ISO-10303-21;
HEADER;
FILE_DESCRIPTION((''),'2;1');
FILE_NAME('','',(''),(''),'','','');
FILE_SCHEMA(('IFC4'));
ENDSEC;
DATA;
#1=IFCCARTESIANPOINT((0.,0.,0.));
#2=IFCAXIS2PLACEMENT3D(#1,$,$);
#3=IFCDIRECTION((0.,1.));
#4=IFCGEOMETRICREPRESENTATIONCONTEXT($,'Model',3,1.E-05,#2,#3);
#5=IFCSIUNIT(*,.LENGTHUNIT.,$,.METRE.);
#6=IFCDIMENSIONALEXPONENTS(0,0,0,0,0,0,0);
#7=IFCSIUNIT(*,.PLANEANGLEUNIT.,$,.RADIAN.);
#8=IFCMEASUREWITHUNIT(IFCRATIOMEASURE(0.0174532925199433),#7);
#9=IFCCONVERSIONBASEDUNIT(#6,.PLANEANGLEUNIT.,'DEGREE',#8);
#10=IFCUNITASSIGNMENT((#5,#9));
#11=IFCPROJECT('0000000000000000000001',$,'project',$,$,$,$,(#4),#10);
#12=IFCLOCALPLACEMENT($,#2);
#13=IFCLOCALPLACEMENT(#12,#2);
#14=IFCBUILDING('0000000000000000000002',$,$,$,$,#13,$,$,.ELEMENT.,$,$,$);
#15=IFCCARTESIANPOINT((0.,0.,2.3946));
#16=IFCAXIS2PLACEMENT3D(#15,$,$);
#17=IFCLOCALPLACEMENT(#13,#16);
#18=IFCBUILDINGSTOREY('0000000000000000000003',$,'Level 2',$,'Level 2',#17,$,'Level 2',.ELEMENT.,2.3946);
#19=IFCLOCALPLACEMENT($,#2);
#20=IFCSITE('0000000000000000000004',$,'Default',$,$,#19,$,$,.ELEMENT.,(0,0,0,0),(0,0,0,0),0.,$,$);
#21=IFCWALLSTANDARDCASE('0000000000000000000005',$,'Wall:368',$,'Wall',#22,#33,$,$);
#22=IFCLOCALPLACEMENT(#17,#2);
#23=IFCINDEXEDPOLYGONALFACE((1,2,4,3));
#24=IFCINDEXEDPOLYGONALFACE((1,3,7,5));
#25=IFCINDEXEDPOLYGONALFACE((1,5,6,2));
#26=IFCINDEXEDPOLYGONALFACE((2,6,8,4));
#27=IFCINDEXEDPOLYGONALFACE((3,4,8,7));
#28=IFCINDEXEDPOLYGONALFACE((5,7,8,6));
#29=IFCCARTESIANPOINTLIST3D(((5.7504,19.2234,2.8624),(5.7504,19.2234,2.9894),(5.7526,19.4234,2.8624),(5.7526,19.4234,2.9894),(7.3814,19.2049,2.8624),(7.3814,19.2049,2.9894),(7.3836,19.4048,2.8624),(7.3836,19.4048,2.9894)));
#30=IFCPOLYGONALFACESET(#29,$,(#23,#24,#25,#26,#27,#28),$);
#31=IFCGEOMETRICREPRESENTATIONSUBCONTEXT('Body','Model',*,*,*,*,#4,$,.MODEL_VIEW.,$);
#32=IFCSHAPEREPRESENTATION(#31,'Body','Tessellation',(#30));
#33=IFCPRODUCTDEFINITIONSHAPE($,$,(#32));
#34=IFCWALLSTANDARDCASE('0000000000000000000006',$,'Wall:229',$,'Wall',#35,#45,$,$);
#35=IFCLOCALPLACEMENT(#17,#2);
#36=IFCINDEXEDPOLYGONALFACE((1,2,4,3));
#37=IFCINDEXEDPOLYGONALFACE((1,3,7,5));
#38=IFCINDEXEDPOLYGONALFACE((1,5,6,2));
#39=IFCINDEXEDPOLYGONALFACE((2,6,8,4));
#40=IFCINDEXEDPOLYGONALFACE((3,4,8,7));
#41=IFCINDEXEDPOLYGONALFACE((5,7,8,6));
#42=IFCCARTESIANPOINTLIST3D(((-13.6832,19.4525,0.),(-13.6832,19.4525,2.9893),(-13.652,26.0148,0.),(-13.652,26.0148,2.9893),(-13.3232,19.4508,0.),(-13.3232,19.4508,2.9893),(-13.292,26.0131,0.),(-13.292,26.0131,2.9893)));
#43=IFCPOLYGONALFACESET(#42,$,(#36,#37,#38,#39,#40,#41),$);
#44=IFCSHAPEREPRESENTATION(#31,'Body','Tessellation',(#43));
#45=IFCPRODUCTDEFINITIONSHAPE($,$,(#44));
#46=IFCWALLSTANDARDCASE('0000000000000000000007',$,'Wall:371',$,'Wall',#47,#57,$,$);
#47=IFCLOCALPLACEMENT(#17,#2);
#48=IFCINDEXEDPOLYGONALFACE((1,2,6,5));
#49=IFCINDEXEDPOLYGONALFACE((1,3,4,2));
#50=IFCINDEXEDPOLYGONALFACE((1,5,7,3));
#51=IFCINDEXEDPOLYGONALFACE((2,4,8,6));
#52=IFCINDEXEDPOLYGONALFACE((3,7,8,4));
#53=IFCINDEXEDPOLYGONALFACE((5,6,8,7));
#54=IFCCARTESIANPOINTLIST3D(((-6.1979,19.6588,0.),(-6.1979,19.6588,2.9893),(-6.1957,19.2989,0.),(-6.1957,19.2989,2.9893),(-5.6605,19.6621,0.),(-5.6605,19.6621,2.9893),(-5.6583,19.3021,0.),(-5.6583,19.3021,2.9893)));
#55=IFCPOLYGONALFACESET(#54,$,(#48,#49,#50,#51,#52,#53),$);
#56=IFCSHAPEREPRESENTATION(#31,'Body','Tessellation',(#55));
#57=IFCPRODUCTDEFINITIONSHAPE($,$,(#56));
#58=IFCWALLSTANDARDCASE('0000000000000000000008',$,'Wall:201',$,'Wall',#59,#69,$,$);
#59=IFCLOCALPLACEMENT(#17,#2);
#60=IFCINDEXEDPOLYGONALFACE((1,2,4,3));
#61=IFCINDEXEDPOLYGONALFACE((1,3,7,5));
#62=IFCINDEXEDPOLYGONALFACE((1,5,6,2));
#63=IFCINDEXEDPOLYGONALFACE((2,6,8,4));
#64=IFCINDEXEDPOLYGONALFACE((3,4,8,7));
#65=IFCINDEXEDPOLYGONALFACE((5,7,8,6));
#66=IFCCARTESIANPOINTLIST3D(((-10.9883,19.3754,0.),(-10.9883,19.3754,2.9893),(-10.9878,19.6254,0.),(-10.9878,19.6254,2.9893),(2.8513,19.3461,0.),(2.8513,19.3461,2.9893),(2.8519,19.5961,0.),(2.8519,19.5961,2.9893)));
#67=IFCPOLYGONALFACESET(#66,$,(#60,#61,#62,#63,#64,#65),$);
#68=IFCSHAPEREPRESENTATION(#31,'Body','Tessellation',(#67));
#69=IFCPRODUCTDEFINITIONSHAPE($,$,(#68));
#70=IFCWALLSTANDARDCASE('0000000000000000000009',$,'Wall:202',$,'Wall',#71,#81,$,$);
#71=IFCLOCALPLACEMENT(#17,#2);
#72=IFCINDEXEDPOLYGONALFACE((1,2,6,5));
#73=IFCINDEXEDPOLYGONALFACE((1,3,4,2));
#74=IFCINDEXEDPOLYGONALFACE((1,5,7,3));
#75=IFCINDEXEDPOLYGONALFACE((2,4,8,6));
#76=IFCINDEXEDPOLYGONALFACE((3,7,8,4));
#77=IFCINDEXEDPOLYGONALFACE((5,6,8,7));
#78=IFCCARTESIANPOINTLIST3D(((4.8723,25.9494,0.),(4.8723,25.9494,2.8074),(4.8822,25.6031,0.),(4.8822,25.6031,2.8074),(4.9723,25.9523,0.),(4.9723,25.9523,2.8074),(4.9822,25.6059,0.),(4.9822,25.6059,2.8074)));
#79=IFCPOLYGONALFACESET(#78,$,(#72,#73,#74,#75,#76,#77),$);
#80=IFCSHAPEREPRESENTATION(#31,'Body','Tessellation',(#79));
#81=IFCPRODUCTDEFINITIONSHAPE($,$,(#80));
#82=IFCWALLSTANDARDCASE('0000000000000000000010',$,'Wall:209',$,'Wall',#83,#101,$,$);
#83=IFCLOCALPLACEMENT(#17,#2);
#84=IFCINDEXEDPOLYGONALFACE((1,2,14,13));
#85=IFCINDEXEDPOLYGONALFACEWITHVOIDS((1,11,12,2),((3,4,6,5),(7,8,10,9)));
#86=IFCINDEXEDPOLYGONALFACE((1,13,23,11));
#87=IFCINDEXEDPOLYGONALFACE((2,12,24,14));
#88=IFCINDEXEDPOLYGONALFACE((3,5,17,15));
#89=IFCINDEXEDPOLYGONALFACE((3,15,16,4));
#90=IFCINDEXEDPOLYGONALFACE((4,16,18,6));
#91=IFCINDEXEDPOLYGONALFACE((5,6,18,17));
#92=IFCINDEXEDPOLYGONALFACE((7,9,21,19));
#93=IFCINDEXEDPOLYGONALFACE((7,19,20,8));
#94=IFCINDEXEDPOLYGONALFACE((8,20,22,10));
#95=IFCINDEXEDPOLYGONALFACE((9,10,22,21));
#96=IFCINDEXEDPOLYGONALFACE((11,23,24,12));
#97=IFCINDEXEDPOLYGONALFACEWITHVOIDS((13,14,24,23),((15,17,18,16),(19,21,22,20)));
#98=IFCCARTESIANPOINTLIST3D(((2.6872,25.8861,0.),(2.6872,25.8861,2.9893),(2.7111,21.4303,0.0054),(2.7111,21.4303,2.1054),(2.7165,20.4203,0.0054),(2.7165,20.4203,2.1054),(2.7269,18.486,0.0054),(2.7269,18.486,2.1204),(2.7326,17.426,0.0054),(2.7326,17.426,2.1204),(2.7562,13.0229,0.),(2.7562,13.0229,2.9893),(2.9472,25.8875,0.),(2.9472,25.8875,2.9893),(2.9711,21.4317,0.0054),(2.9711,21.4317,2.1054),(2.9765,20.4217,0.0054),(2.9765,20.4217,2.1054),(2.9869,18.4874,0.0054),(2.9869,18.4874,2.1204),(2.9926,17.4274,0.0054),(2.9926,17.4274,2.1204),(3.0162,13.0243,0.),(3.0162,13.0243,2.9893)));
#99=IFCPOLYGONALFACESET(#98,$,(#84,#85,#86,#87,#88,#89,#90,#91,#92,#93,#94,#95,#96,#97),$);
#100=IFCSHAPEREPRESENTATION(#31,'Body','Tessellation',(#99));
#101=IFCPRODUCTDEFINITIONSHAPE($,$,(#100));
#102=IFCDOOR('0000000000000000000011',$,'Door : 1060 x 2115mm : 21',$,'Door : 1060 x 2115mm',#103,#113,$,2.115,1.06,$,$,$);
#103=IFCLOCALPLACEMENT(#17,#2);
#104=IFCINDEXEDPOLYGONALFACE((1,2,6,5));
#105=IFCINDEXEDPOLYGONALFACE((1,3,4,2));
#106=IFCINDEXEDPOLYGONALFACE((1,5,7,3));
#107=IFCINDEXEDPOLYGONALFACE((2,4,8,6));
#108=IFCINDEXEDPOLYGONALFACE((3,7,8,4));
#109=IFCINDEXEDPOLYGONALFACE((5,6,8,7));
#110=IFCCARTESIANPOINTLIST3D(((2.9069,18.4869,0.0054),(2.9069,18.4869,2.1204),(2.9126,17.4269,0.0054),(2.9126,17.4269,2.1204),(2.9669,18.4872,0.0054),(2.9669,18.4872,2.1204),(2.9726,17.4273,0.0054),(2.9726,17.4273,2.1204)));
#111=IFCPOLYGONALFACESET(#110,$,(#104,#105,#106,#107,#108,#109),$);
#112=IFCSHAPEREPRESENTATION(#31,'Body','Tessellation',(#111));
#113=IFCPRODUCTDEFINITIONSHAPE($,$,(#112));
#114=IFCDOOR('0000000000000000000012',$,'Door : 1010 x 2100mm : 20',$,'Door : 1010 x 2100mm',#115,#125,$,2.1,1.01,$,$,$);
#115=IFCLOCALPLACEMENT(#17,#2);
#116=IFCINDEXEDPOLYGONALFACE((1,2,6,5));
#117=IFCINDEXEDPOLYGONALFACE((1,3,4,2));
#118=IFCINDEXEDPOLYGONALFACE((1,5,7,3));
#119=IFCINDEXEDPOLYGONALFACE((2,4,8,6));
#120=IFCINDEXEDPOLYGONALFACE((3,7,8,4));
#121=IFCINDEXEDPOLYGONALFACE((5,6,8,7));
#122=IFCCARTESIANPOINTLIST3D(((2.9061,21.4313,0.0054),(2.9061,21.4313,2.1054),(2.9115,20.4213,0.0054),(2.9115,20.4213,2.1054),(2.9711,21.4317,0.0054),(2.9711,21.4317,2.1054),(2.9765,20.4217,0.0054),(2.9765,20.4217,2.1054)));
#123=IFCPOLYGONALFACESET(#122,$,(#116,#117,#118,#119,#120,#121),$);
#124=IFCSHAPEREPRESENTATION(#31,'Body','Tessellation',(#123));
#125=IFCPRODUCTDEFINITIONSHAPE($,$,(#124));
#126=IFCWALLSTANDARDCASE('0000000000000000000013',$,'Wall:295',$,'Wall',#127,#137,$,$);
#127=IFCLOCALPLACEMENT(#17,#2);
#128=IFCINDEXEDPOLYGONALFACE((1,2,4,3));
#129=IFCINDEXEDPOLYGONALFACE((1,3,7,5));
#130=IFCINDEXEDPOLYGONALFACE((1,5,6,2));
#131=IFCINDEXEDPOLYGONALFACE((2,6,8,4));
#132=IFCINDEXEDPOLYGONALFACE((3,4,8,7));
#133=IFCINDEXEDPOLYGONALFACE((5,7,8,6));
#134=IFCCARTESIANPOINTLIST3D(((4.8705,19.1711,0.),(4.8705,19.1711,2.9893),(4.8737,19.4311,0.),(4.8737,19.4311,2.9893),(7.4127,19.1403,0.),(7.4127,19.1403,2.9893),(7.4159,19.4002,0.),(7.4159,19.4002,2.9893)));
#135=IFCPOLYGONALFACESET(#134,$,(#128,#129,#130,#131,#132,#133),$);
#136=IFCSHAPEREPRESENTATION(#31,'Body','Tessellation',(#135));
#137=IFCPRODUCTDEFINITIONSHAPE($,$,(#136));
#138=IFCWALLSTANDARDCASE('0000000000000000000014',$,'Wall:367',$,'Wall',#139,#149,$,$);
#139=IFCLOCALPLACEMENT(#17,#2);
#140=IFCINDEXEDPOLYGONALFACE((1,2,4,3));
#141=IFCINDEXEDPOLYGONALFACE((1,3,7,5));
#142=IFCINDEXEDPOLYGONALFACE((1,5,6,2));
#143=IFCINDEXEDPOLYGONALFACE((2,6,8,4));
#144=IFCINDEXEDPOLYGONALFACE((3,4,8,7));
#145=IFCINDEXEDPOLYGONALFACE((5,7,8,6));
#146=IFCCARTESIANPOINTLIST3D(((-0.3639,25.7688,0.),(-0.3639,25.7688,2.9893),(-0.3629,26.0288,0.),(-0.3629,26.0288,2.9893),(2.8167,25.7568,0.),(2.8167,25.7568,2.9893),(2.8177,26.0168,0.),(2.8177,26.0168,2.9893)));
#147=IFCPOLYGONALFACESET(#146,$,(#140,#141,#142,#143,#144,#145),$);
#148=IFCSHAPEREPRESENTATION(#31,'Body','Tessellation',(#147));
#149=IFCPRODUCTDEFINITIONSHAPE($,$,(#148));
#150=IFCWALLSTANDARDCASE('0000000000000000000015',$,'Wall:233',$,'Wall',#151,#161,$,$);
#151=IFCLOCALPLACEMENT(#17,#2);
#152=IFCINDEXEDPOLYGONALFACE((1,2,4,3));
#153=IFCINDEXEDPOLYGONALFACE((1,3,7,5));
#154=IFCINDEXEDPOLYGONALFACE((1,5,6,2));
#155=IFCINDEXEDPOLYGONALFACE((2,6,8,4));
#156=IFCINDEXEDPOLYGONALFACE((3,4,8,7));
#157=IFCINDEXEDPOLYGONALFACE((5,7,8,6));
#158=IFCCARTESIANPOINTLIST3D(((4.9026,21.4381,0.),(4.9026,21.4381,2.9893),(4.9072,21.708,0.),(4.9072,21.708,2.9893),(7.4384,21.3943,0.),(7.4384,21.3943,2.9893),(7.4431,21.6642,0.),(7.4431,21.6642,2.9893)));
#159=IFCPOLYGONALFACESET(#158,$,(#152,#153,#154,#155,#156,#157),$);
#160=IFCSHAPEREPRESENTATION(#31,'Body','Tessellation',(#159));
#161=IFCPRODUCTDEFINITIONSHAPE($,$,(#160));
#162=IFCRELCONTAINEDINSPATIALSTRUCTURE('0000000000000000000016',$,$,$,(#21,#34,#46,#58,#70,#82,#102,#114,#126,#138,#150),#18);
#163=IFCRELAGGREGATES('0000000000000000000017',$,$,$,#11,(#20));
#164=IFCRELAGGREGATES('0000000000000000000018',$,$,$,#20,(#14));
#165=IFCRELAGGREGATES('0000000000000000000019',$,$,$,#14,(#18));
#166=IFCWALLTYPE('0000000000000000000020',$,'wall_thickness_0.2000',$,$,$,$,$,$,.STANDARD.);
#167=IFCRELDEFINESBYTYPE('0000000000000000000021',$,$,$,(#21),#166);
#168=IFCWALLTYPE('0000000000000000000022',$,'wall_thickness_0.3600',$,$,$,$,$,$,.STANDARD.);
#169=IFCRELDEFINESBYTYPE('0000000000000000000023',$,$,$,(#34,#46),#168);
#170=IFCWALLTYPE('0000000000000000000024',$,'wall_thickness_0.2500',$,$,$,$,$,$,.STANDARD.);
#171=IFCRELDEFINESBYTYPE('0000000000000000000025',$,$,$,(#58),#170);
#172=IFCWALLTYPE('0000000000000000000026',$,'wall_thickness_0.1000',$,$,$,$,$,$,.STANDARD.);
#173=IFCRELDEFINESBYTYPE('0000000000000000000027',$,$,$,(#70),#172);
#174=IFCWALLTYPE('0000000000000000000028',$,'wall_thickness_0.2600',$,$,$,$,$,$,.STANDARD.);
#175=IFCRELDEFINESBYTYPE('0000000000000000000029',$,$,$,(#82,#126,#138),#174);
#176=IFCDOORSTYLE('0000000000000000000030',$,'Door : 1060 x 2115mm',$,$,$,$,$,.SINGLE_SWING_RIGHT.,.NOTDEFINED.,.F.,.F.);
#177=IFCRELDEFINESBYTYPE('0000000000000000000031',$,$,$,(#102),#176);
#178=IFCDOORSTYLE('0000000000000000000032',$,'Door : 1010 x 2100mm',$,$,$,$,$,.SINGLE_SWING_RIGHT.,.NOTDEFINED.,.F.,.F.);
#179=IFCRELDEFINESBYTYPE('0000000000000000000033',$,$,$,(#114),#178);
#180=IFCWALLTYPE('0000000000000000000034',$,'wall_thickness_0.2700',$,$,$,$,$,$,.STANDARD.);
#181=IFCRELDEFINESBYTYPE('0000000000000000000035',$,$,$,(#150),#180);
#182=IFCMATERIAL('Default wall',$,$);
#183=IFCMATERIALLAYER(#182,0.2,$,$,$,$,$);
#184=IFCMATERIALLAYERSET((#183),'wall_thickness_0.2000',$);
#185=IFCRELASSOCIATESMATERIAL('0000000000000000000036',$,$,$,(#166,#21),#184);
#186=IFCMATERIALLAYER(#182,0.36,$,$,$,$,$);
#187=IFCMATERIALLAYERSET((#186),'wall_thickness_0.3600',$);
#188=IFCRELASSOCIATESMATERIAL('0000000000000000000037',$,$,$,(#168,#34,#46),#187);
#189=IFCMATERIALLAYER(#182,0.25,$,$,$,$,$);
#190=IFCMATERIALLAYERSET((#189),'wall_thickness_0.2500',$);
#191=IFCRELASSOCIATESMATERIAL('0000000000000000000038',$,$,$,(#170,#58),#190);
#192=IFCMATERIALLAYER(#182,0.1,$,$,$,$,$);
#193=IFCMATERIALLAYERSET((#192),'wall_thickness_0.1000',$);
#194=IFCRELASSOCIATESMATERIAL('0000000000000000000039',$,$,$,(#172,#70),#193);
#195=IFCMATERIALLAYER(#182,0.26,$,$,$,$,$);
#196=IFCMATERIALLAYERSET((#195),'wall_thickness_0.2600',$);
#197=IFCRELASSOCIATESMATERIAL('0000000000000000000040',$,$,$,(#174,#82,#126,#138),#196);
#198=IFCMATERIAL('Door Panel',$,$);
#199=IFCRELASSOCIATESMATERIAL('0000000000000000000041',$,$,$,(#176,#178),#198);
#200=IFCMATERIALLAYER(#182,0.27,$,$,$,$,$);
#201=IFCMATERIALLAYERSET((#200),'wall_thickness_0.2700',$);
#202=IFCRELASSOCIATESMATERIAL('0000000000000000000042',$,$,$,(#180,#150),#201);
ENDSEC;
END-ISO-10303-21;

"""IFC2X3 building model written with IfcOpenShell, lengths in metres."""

from ifc_helpers import new_model, entity, si_unit, converted_unit, direction, frame, frame_2d, origin, origin_2d_with_axis, place, context, subcontext, project, spatial, polyline, rectangle, outline, extrude, source, transform, mapped, material, layer, layer_set, layer_usage, type_object, type_shapes, element, fill, save


model = new_model("IFC2X3")

# Units and contexts
model_context = context("Model", 3, precision=1e-05, world=origin(), true_north=direction((0.0, 1.0)))
body_context = subcontext(model_context, "Body", "Model", "MODEL_VIEW")
ifc_project = project(units=[si_unit("LENGTHUNIT", "METRE"), converted_unit("PLANEANGLEUNIT", "DEGREE", entity("IfcRatioMeasure", 0.0174532925199433), si_unit("PLANEANGLEUNIT", "RADIAN"), dimensions=[0, 0, 0, 0, 0, 0, 0])], contexts=[model_context])

# Site, building, storey
site_placement = place(None, origin())
site = spatial("IfcSite", under=ifc_project, at=site_placement, Name="Default", CompositionType="ELEMENT", RefLatitude=(0, 0, 0, 0), RefLongitude=(0, 0, 0, 0), RefElevation=0.0)
placement_1 = place(None, origin())
building_placement = place(placement_1, origin())
building = spatial("IfcBuilding", under=site, at=building_placement, CompositionType="ELEMENT")
storey_placement = place(building_placement, frame((0.0, 0.0, 2.3946)))
storey = spatial("IfcBuildingStorey", under=building, at=storey_placement, Name="Level 2", ObjectType="Level 2", LongName="Level 2", CompositionType="ELEMENT", Elevation=2.3946)

# Shared definitions
ifc_material_1 = material(Name="Default wall")

# Walls
ifc_layer_1 = layer(ifc_material_1, 0.2)
ifc_layer_set_1 = layer_set([ifc_layer_1], Name="wall_thickness_0.2000")
ifc_layer_usage_1 = layer_usage(ifc_layer_set_1, "AXIS2", "POSITIVE", -0.1)
wall_type_1 = type_object("IfcWallType", Name="wall_thickness_0.2000", PredefinedType="STANDARD", material=ifc_layer_set_1)
placement_2 = place(building_placement, frame((0.0, 0.0, 5.257)))
wall_1_placement = place(placement_2, frame((5.7515, 19.3234, 0.0), z_axis=(0.0, 0.0, 1.0), x_axis=(0.999935, -0.011381, 0.0)))
element("IfcWallStandardCase", 1, at=wall_1_placement, inside=storey, type_object=wall_type_1, material=ifc_layer_usage_1, Name="Wall:368", ObjectType="Wall", context=body_context, shape_type="SweptSolid", body=[
    extrude(outline(polyline([(1.6311, -0.1), (1.6311, 0.1), (0.0, 0.1), (0.0, -0.1), (1.6311, -0.1)])), origin(), (0.0, 0.0, 1.0), 0.127),
])
ifc_layer_2 = layer(ifc_material_1, 0.36)
ifc_layer_set_2 = layer_set([ifc_layer_2], Name="wall_thickness_0.3600")
ifc_layer_usage_2 = layer_usage(ifc_layer_set_2, "AXIS2", "POSITIVE", -0.18)
wall_type_2 = type_object("IfcWallType", Name="wall_thickness_0.3600", PredefinedType="STANDARD", material=ifc_layer_set_2)
wall_2_placement = place(storey_placement, frame((-13.472, 26.014, 0.0), z_axis=(0.0, 0.0, 1.0), x_axis=(-0.004758, -0.999989, 0.0)))
element("IfcWallStandardCase", 2, at=wall_2_placement, inside=storey, type_object=wall_type_2, material=ifc_layer_usage_2, Name="Wall:229", ObjectType="Wall", context=body_context, shape_type="SweptSolid", body=[
    extrude(outline(polyline([(6.5624, -0.18), (6.5624, 0.18), (0.0, 0.18), (0.0, -0.18), (6.5624, -0.18)])), origin(), (0.0, 0.0, 1.0), 2.9893),
])
wall_3_placement = place(storey_placement, frame((-6.1968, 19.4788, 0.0), z_axis=(0.0, 0.0, 1.0), x_axis=(0.999982, 0.005995, 0.0)))
element("IfcWallStandardCase", 3, at=wall_3_placement, inside=storey, type_object=wall_type_2, material=ifc_layer_usage_2, Name="Wall:371", ObjectType="Wall", context=body_context, shape_type="SweptSolid", body=[
    extrude(outline(polyline([(0.5374, -0.18), (0.5374, 0.18), (0.0, 0.18), (0.0, -0.18), (0.5374, -0.18)])), origin(), (0.0, 0.0, 1.0), 2.9893),
])
ifc_layer_3 = layer(ifc_material_1, 0.25)
ifc_layer_set_3 = layer_set([ifc_layer_3], Name="wall_thickness_0.2500")
ifc_layer_usage_3 = layer_usage(ifc_layer_set_3, "AXIS2", "POSITIVE", -0.125)
wall_type_3 = type_object("IfcWallType", Name="wall_thickness_0.2500", PredefinedType="STANDARD", material=ifc_layer_set_3)
wall_4_placement = place(storey_placement, frame((-10.988, 19.5004, 0.0), z_axis=(0.0, 0.0, 1.0), x_axis=(0.999998, -0.002111, 0.0)))
element("IfcWallStandardCase", 4, at=wall_4_placement, inside=storey, type_object=wall_type_3, material=ifc_layer_usage_3, Name="Wall:201", ObjectType="Wall", context=body_context, shape_type="SweptSolid", body=[
    extrude(outline(polyline([(13.8397, -0.125), (13.8397, 0.125), (0.0, 0.125), (0.0, -0.125), (13.8397, -0.125)])), origin(), (0.0, 0.0, 1.0), 2.9893),
])
ifc_layer_4 = layer(ifc_material_1, 0.1)
ifc_layer_set_4 = layer_set([ifc_layer_4], Name="wall_thickness_0.1000")
ifc_layer_usage_4 = layer_usage(ifc_layer_set_4, "AXIS2", "POSITIVE", -0.05)
wall_type_4 = type_object("IfcWallType", Name="wall_thickness_0.1000", PredefinedType="STANDARD", material=ifc_layer_set_4)
wall_5_placement = place(storey_placement, frame((4.9223, 25.9509, 0.0), z_axis=(0.0, 0.0, 1.0), x_axis=(0.028567, -0.999592, 0.0)))
element("IfcWallStandardCase", 5, at=wall_5_placement, inside=storey, type_object=wall_type_4, material=ifc_layer_usage_4, Name="Wall:202", ObjectType="Wall", context=body_context, shape_type="SweptSolid", body=[
    extrude(outline(polyline([(0.3465, -0.05), (0.3465, 0.05), (0.0, 0.05), (0.0, -0.05), (0.3465, -0.05)])), origin(), (0.0, 0.0, 1.0), 2.8074),
])

# Wall, openings, doors
ifc_layer_5 = layer(ifc_material_1, 0.26)
ifc_layer_set_5 = layer_set([ifc_layer_5], Name="wall_thickness_0.2600")
ifc_layer_usage_5 = layer_usage(ifc_layer_set_5, "AXIS2", "POSITIVE", -0.13)
wall_type_5 = type_object("IfcWallType", Name="wall_thickness_0.2600", PredefinedType="STANDARD", material=ifc_layer_set_5)
wall_6_placement = place(storey_placement, frame((2.8172, 25.8868, 0.0), z_axis=(0.0, 0.0, 1.0), x_axis=(0.005369, -0.999986, 0.0)))
wall_6 = element("IfcWallStandardCase", 6, at=wall_6_placement, inside=storey, type_object=wall_type_5, material=ifc_layer_usage_5, Name="Wall:209", ObjectType="Wall", context=body_context, shape_type="SweptSolid", body=[
    extrude(outline(polyline([(12.8634, -0.13), (12.8634, 0.13), (0.0, 0.13), (0.0, -0.13), (12.8634, -0.13)])), origin(), (0.0, 0.0, 1.0), 2.9893),
])
opening_1_placement = place(wall_6_placement, frame((4.4559, -0.13, 0.0054)))
opening_1 = element("IfcOpeningElement", 7, at=opening_1_placement, cuts=wall_6, ObjectType="Opening", context=body_context, shape_type="SweptSolid", body=[
    extrude(rectangle(XDim=1.01, YDim=2.1, at=frame_2d((1.05, 0.505), x_axis=(0.0, 1.0))), frame((0.0, 0.0, 0.0), z_axis=(0.0, 1.0, 0.0), x_axis=(0.0, 0.0, 1.0)), (0.0, 0.0, 1.0), 0.26),
])
opening_2_placement = place(wall_6_placement, frame((7.4002, -0.13, 0.0054)))
opening_2 = element("IfcOpeningElement", 8, at=opening_2_placement, cuts=wall_6, ObjectType="Opening", context=body_context, shape_type="SweptSolid", body=[
    extrude(rectangle(XDim=1.06, YDim=2.115, at=frame_2d((1.0575, 0.53), x_axis=(0.0, 1.0))), frame((0.0, 0.0, 0.0), z_axis=(0.0, 1.0, 0.0), x_axis=(0.0, 0.0, 1.0)), (0.0, 0.0, 1.0), 0.26),
])
ifc_material_2 = material(Name="Door Panel")
door_style_1 = type_object("IfcDoorStyle", Name="Door : 1060 x 2115mm", ConstructionType="NOTDEFINED", OperationType="SINGLE_SWING_RIGHT", ParameterTakesPrecedence=False, Sizeable=False, material=ifc_material_2)
shared_shape_1 = source(origin(), body_context, "Body", "SweptSolid", [
    extrude(rectangle(XDim=0.06, YDim=1.06, at=origin_2d_with_axis()), frame((0.53, 0.21, 0.0), z_axis=(0.0, 0.0, 1.0), x_axis=(0.0, 1.0, 0.0)), (0.0, 0.0, 1.0), 2.115),
])
type_shapes(door_style_1, [shared_shape_1])
door_1_placement = place(opening_2_placement, origin())
door_1 = element("IfcDoor", 9, at=door_1_placement, inside=storey, type_object=door_style_1, Name="Door : 1060 x 2115mm : 21", ObjectType="Door : 1060 x 2115mm", OverallHeight=2.115, OverallWidth=1.06, context=body_context, shape_type="MappedRepresentation", body=[
    mapped(shared_shape_1, transform((0.0, 0.0, 0.0), scale=1.0)),
])
fill(opening_2, door_1)
door_style_2 = type_object("IfcDoorStyle", Name="Door : 1010 x 2100mm", ConstructionType="NOTDEFINED", OperationType="SINGLE_SWING_RIGHT", ParameterTakesPrecedence=False, Sizeable=False, material=ifc_material_2)
shared_shape_2 = source(origin(), body_context, "Body", "SweptSolid", [
    extrude(rectangle(XDim=0.065, YDim=1.01, at=origin_2d_with_axis()), frame((0.505, 0.2275, 0.0), z_axis=(0.0, 0.0, 1.0), x_axis=(0.0, 1.0, 0.0)), (0.0, 0.0, 1.0), 2.1),
])
type_shapes(door_style_2, [shared_shape_2])
door_2_placement = place(opening_1_placement, origin())
door_2 = element("IfcDoor", 10, at=door_2_placement, inside=storey, type_object=door_style_2, Name="Door : 1010 x 2100mm : 20", ObjectType="Door : 1010 x 2100mm", OverallHeight=2.1, OverallWidth=1.01, context=body_context, shape_type="MappedRepresentation", body=[
    mapped(shared_shape_2, transform((0.0, 0.0, 0.0), scale=1.0)),
])
fill(opening_1, door_2)

# Walls
wall_7_placement = place(storey_placement, frame((4.8721, 19.3011, 0.0), z_axis=(0.0, 0.0, 1.0), x_axis=(0.999926, -0.012128, 0.0)))
element("IfcWallStandardCase", 11, at=wall_7_placement, inside=storey, type_object=wall_type_5, material=ifc_layer_usage_5, Name="Wall:295", ObjectType="Wall", context=body_context, shape_type="SweptSolid", body=[
    extrude(outline(polyline([(2.5424, -0.13), (2.5424, 0.13), (0.0, 0.13), (0.0, -0.13), (2.5424, -0.13)])), origin(), (0.0, 0.0, 1.0), 2.9893),
])
wall_8_placement = place(storey_placement, frame((-0.3634, 25.8988, 0.0), z_axis=(0.0, 0.0, 1.0), x_axis=(0.999993, -0.003794, 0.0)))
element("IfcWallStandardCase", 12, at=wall_8_placement, inside=storey, type_object=wall_type_5, material=ifc_layer_usage_5, Name="Wall:367", ObjectType="Wall", context=body_context, shape_type="SweptSolid", body=[
    extrude(outline(polyline([(3.1806, -0.13), (3.1806, 0.13), (0.0, 0.13), (0.0, -0.13), (3.1806, -0.13)])), origin(), (0.0, 0.0, 1.0), 2.9893),
])
ifc_layer_6 = layer(ifc_material_1, 0.27)
ifc_layer_set_6 = layer_set([ifc_layer_6], Name="wall_thickness_0.2700")
ifc_layer_usage_6 = layer_usage(ifc_layer_set_6, "AXIS2", "POSITIVE", -0.135)
wall_type_6 = type_object("IfcWallType", Name="wall_thickness_0.2700", PredefinedType="STANDARD", material=ifc_layer_set_6)
wall_9_placement = place(storey_placement, frame((4.9049, 21.5731, 0.0), z_axis=(0.0, 0.0, 1.0), x_axis=(0.999851, -0.017274, 0.0)))
element("IfcWallStandardCase", 13, at=wall_9_placement, inside=storey, type_object=wall_type_6, material=ifc_layer_usage_6, Name="Wall:233", ObjectType="Wall", context=body_context, shape_type="SweptSolid", body=[
    extrude(outline(polyline([(2.5362, -0.135), (2.5362, 0.135), (0.0, 0.135), (0.0, -0.135), (2.5362, -0.135)])), origin(), (0.0, 0.0, 1.0), 2.9893),
])

save(model, "model.ifc")
